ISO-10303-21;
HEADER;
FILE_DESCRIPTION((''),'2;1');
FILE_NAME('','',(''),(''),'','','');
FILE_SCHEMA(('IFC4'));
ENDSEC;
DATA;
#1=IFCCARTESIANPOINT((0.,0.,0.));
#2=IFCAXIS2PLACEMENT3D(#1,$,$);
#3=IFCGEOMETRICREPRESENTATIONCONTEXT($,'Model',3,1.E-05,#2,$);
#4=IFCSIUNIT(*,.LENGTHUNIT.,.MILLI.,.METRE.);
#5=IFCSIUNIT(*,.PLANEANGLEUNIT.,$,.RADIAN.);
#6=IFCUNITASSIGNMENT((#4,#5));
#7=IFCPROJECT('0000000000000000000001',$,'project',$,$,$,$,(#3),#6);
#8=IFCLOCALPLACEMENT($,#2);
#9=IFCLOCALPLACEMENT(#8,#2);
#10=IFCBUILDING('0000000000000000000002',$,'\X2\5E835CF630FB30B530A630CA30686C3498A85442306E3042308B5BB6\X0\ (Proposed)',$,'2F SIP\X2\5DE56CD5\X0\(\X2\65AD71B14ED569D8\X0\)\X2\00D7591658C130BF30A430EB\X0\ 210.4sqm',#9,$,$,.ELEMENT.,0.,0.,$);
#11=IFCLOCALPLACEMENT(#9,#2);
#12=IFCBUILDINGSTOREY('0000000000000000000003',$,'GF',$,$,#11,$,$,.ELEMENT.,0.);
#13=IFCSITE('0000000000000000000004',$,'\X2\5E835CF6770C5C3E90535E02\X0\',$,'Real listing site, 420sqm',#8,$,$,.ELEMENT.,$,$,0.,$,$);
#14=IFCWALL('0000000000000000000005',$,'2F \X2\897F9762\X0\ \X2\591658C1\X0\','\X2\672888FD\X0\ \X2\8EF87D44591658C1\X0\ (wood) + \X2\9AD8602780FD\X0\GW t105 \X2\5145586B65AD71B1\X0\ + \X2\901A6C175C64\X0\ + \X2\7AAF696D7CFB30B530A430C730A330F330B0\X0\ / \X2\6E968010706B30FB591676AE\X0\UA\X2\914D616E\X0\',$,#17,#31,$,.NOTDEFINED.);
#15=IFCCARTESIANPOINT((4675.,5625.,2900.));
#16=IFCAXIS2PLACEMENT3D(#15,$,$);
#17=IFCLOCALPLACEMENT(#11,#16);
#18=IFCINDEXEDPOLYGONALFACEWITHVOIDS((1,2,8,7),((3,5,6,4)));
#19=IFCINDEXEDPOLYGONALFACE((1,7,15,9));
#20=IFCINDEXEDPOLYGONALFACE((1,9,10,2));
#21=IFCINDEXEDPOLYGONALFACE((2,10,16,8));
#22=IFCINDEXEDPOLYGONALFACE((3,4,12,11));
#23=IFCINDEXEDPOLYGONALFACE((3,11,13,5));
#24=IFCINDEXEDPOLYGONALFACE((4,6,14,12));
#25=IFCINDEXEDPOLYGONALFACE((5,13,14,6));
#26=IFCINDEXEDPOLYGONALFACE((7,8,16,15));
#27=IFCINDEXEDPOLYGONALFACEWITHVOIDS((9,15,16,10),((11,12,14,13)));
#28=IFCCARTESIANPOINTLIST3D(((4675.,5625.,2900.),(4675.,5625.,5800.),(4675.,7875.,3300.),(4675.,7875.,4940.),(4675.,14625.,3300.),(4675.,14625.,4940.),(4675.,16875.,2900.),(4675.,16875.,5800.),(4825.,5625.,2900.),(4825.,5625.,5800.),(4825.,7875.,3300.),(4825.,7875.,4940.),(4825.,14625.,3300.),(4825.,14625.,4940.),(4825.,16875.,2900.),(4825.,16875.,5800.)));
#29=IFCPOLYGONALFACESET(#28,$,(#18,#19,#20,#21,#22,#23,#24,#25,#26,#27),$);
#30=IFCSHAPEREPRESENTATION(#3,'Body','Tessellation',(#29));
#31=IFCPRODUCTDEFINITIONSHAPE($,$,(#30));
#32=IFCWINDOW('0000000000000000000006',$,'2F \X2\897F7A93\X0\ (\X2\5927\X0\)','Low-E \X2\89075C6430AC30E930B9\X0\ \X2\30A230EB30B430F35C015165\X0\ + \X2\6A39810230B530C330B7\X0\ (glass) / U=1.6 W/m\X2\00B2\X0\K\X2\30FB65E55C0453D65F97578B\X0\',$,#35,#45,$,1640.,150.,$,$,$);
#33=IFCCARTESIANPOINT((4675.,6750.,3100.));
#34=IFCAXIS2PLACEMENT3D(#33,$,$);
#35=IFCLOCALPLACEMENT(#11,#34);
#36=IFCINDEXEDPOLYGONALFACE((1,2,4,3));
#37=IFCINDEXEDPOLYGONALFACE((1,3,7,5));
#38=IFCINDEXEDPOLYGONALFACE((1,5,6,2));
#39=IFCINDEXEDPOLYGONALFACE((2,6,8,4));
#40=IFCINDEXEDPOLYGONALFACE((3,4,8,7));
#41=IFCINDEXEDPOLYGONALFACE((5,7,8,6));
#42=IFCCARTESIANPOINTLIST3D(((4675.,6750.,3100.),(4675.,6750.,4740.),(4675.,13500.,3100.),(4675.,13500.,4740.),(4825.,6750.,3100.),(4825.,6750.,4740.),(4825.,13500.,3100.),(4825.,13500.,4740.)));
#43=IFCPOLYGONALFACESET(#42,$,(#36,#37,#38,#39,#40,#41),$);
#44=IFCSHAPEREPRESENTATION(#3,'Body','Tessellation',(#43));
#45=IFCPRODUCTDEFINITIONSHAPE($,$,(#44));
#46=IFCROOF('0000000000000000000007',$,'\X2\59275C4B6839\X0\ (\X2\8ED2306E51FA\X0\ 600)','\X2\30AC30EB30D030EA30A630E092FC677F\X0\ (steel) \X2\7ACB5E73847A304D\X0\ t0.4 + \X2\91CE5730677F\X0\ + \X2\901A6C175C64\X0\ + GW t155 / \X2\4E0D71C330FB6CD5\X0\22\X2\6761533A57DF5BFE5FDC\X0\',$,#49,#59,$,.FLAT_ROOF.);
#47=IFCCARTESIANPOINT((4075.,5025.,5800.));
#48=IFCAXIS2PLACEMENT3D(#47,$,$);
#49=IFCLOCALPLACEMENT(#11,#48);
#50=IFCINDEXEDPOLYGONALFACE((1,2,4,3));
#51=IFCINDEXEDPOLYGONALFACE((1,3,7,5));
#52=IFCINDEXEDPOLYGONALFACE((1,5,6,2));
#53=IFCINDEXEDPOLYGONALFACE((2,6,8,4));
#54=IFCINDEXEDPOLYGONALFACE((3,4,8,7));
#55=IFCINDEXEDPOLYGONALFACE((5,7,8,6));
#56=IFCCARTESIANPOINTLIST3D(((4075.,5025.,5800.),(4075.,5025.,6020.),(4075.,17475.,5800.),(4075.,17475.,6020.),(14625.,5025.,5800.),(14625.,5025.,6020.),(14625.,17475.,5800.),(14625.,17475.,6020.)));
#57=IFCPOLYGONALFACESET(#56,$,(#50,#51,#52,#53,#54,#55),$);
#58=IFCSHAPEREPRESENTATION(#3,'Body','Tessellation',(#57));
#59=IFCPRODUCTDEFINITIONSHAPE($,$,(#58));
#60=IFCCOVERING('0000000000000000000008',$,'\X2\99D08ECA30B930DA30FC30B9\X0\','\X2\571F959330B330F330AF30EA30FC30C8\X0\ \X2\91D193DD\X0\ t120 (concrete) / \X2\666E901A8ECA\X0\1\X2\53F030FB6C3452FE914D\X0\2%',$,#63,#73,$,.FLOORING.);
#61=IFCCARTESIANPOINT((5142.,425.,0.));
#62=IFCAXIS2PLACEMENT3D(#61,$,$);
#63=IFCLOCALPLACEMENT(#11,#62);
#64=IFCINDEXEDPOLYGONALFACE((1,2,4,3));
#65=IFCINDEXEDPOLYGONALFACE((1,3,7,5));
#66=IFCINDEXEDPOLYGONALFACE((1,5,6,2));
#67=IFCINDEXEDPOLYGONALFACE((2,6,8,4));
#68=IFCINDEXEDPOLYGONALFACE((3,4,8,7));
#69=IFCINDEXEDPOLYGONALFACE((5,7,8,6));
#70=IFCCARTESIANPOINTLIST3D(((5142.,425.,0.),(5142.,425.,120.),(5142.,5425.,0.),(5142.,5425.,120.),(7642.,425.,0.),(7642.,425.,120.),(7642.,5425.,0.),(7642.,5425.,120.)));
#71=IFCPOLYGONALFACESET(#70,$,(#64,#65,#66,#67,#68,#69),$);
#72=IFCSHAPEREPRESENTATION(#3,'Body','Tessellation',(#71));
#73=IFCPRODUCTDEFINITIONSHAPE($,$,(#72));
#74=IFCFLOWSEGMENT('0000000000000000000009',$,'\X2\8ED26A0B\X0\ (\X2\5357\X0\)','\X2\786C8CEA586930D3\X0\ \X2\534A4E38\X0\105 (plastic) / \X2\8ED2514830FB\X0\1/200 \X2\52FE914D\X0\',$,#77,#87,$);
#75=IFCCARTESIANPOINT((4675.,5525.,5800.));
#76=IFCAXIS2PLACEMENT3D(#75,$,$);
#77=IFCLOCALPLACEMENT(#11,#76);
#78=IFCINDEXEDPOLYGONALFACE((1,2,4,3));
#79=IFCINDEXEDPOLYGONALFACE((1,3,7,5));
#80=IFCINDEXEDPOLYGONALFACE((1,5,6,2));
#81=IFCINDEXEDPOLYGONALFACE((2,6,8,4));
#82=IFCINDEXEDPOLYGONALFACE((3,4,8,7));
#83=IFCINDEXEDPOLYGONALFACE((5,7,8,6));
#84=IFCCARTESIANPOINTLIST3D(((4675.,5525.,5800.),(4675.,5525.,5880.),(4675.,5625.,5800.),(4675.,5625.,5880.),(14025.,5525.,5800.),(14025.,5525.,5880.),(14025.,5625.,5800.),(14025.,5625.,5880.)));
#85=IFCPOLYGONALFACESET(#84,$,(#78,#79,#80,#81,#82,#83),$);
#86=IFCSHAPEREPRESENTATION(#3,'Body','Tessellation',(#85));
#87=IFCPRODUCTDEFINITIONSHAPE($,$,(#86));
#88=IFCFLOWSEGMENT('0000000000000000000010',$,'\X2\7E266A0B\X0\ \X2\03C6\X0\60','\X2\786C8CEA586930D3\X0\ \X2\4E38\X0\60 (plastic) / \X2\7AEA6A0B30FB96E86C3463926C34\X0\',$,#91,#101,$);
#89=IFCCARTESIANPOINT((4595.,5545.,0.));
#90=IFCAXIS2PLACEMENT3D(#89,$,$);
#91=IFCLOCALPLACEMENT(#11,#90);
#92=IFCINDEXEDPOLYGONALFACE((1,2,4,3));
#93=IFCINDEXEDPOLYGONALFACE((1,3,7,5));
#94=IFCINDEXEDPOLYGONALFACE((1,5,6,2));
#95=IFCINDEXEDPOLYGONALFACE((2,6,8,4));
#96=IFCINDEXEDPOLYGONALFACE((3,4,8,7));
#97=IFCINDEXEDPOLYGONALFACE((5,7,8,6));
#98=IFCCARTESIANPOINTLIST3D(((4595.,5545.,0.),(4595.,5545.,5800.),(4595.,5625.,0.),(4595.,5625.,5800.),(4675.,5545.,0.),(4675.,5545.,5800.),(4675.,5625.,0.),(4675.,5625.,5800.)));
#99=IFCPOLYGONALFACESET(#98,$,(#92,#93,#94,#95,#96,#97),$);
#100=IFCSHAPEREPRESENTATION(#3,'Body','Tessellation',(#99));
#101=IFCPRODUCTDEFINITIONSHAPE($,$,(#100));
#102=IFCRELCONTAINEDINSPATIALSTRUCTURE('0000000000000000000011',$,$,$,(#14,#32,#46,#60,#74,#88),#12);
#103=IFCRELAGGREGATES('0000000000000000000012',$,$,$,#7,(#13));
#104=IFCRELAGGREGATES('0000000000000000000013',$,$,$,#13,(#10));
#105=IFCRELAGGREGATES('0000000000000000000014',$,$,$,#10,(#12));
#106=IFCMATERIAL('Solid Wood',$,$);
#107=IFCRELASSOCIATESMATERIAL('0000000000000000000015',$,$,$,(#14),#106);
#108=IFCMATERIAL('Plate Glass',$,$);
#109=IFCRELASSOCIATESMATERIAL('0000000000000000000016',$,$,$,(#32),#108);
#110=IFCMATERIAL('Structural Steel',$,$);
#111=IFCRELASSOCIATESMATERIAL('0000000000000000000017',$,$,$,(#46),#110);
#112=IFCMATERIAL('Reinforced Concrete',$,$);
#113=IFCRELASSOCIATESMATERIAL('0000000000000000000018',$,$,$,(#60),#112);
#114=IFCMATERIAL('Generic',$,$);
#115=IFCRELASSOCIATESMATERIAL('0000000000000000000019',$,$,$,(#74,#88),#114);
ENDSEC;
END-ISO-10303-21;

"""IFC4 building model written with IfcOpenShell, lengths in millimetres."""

from ifc_helpers import new_model, si_unit, frame, frame_2d, origin, place, context, project, spatial, rectangle, extrude, material, element, fill, save


model = new_model("IFC4")

# Units and contexts
model_context = context("Model", 3, precision=1e-05, world=origin())
ifc_project = project(units=[si_unit("LENGTHUNIT", "METRE", prefix="MILLI"), si_unit("PLANEANGLEUNIT", "RADIAN")], contexts=[model_context])

# Site, building, storey
site_placement = place(None, origin())
site = spatial("IfcSite", under=ifc_project, at=site_placement, Name="広島県尾道市", ObjectType="Real listing site, 420sqm", CompositionType="ELEMENT", RefElevation=0.0)
building_placement = place(site_placement, origin())
building = spatial("IfcBuilding", under=site, at=building_placement, Name="広島・サウナと水風呂のある家 (Proposed)", ObjectType="2F SIP工法(断熱仕様)×外壁タイル 210.4sqm", CompositionType="ELEMENT", ElevationOfRefHeight=0.0, ElevationOfTerrain=0.0)
storey_placement = place(building_placement, origin())
storey = spatial("IfcBuildingStorey", under=building, at=storey_placement, Name="GF", CompositionType="ELEMENT", Elevation=0.0)

# Shared definitions
ifc_material_1 = material(Name="Solid Wood")

# Shared definitions
ifc_material_2 = material(Name="Reinforced Concrete")

# Shared definitions
ifc_material_3 = material(Name="Plate Glass")

# Wall, opening, window
wall_1_placement = place(storey_placement, frame((4675.0, 5625.0, 2900.0)))
wall_1 = element("IfcWall", 1, at=wall_1_placement, inside=storey, material=ifc_material_1, Name="2F 西面 外壁", Description="木製 軸組外壁 (wood) + 高性能GW t105 充填断熱 + 通気層 + 窯業系サイディング / 準耐火・外皮UA配慮", PredefinedType="NOTDEFINED", context=model_context, shape_type="SweptSolid", body=[
    extrude(rectangle(XDim=150.0, YDim=11250.0, at=frame_2d((75.0, 5625.0))), frame((4675.0, 5625.0, 2900.0)), (0.0, 0.0, 1.0), 2900.0),
])
opening_1_placement = place(storey_placement, frame((4675.0, 6750.0, 3100.0)))
opening_1 = element("IfcOpeningElement", 2, at=opening_1_placement, cuts=wall_1, PredefinedType="NOTDEFINED", context=model_context, shape_type="SweptSolid", body=[
    extrude(rectangle(XDim=150.0, YDim=6750.0, at=frame_2d((75.0, 3375.0))), frame((4675.0, 6750.0, 3100.0)), (0.0, 0.0, 1.0), 1640.0),
])
window_1_placement = place(storey_placement, frame((4675.0, 6750.0, 3100.0)))
window_1 = element("IfcWindow", 3, at=window_1_placement, inside=storey, material=ifc_material_3, Name="2F 西窓 (大)", Description="Low-E 複層ガラス アルゴン封入 + 樹脂サッシ (glass) / U=1.6 W/m²K・日射取得型", OverallHeight=1640.0, OverallWidth=150.0, context=model_context, shape_type="SweptSolid", body=[
    extrude(rectangle(XDim=150.0, YDim=6750.0, at=frame_2d((75.0, 3375.0))), frame((4675.0, 6750.0, 3100.0)), (0.0, 0.0, 1.0), 1640.0),
])
fill(opening_1, window_1)

# Roof
ifc_material_4 = material(Name="Structural Steel")
roof_placement = place(storey_placement, frame((4075.0, 5025.0, 5800.0)))
element("IfcRoof", 4, at=roof_placement, inside=storey, material=ifc_material_4, Name="大屋根 (軒の出 600)", Description="ガルバリウム鋼板 (steel) 立平葺き t0.4 + 野地板 + 通気層 + GW t155 / 不燃・法22条区域対応", PredefinedType="FLAT_ROOF", context=model_context, shape_type="SweptSolid", body=[
    extrude(rectangle(XDim=10550.0, YDim=12450.0, at=frame_2d((5275.0, 6225.0))), frame((4075.0, 5025.0, 5800.0)), (0.0, 0.0, 1.0), 220.0),
])

# Covering
covering_placement = place(storey_placement, frame((5142.0, 425.0, 0.0)))
element("IfcCovering", 5, at=covering_placement, inside=storey, material=ifc_material_2, Name="駐車スペース", Description="土間コンクリート 金鏝 t120 (concrete) / 普通車1台・水勾配2%", PredefinedType="FLOORING", context=model_context, shape_type="SweptSolid", body=[
    extrude(rectangle(XDim=2500.0, YDim=5000.0, at=frame_2d((1250.0, 2500.0))), frame((5142.0, 425.0, 0.0)), (0.0, 0.0, 1.0), 120.0),
])

# Flow segments
ifc_material_5 = material(Name="Generic")
flow_segment_1_placement = place(storey_placement, frame((4675.0, 5525.0, 5800.0)))
element("IfcFlowSegment", 6, at=flow_segment_1_placement, inside=storey, material=ifc_material_5, Name="軒樋 (南)", Description="硬質塩ビ 半丸105 (plastic) / 軒先・1/200 勾配", context=model_context, shape_type="SweptSolid", body=[
    extrude(rectangle(XDim=9350.0, YDim=100.0, at=frame_2d((4675.0, 50.0))), frame((4675.0, 5525.0, 5800.0)), (0.0, 0.0, 1.0), 80.0),
])
flow_segment_2_placement = place(storey_placement, frame((4595.0, 5545.0, 0.0)))
element("IfcFlowSegment", 7, at=flow_segment_2_placement, inside=storey, material=ifc_material_5, Name="縦樋 φ60", Description="硬質塩ビ 丸60 (plastic) / 竪樋・雨水排水", context=model_context, shape_type="SweptSolid", body=[
    extrude(rectangle(XDim=80.0, YDim=80.0, at=frame_2d((40.0, 40.0))), frame((4595.0, 5545.0, 0.0)), (0.0, 0.0, 1.0), 5800.0),
])

save(model, "model.ifc")
